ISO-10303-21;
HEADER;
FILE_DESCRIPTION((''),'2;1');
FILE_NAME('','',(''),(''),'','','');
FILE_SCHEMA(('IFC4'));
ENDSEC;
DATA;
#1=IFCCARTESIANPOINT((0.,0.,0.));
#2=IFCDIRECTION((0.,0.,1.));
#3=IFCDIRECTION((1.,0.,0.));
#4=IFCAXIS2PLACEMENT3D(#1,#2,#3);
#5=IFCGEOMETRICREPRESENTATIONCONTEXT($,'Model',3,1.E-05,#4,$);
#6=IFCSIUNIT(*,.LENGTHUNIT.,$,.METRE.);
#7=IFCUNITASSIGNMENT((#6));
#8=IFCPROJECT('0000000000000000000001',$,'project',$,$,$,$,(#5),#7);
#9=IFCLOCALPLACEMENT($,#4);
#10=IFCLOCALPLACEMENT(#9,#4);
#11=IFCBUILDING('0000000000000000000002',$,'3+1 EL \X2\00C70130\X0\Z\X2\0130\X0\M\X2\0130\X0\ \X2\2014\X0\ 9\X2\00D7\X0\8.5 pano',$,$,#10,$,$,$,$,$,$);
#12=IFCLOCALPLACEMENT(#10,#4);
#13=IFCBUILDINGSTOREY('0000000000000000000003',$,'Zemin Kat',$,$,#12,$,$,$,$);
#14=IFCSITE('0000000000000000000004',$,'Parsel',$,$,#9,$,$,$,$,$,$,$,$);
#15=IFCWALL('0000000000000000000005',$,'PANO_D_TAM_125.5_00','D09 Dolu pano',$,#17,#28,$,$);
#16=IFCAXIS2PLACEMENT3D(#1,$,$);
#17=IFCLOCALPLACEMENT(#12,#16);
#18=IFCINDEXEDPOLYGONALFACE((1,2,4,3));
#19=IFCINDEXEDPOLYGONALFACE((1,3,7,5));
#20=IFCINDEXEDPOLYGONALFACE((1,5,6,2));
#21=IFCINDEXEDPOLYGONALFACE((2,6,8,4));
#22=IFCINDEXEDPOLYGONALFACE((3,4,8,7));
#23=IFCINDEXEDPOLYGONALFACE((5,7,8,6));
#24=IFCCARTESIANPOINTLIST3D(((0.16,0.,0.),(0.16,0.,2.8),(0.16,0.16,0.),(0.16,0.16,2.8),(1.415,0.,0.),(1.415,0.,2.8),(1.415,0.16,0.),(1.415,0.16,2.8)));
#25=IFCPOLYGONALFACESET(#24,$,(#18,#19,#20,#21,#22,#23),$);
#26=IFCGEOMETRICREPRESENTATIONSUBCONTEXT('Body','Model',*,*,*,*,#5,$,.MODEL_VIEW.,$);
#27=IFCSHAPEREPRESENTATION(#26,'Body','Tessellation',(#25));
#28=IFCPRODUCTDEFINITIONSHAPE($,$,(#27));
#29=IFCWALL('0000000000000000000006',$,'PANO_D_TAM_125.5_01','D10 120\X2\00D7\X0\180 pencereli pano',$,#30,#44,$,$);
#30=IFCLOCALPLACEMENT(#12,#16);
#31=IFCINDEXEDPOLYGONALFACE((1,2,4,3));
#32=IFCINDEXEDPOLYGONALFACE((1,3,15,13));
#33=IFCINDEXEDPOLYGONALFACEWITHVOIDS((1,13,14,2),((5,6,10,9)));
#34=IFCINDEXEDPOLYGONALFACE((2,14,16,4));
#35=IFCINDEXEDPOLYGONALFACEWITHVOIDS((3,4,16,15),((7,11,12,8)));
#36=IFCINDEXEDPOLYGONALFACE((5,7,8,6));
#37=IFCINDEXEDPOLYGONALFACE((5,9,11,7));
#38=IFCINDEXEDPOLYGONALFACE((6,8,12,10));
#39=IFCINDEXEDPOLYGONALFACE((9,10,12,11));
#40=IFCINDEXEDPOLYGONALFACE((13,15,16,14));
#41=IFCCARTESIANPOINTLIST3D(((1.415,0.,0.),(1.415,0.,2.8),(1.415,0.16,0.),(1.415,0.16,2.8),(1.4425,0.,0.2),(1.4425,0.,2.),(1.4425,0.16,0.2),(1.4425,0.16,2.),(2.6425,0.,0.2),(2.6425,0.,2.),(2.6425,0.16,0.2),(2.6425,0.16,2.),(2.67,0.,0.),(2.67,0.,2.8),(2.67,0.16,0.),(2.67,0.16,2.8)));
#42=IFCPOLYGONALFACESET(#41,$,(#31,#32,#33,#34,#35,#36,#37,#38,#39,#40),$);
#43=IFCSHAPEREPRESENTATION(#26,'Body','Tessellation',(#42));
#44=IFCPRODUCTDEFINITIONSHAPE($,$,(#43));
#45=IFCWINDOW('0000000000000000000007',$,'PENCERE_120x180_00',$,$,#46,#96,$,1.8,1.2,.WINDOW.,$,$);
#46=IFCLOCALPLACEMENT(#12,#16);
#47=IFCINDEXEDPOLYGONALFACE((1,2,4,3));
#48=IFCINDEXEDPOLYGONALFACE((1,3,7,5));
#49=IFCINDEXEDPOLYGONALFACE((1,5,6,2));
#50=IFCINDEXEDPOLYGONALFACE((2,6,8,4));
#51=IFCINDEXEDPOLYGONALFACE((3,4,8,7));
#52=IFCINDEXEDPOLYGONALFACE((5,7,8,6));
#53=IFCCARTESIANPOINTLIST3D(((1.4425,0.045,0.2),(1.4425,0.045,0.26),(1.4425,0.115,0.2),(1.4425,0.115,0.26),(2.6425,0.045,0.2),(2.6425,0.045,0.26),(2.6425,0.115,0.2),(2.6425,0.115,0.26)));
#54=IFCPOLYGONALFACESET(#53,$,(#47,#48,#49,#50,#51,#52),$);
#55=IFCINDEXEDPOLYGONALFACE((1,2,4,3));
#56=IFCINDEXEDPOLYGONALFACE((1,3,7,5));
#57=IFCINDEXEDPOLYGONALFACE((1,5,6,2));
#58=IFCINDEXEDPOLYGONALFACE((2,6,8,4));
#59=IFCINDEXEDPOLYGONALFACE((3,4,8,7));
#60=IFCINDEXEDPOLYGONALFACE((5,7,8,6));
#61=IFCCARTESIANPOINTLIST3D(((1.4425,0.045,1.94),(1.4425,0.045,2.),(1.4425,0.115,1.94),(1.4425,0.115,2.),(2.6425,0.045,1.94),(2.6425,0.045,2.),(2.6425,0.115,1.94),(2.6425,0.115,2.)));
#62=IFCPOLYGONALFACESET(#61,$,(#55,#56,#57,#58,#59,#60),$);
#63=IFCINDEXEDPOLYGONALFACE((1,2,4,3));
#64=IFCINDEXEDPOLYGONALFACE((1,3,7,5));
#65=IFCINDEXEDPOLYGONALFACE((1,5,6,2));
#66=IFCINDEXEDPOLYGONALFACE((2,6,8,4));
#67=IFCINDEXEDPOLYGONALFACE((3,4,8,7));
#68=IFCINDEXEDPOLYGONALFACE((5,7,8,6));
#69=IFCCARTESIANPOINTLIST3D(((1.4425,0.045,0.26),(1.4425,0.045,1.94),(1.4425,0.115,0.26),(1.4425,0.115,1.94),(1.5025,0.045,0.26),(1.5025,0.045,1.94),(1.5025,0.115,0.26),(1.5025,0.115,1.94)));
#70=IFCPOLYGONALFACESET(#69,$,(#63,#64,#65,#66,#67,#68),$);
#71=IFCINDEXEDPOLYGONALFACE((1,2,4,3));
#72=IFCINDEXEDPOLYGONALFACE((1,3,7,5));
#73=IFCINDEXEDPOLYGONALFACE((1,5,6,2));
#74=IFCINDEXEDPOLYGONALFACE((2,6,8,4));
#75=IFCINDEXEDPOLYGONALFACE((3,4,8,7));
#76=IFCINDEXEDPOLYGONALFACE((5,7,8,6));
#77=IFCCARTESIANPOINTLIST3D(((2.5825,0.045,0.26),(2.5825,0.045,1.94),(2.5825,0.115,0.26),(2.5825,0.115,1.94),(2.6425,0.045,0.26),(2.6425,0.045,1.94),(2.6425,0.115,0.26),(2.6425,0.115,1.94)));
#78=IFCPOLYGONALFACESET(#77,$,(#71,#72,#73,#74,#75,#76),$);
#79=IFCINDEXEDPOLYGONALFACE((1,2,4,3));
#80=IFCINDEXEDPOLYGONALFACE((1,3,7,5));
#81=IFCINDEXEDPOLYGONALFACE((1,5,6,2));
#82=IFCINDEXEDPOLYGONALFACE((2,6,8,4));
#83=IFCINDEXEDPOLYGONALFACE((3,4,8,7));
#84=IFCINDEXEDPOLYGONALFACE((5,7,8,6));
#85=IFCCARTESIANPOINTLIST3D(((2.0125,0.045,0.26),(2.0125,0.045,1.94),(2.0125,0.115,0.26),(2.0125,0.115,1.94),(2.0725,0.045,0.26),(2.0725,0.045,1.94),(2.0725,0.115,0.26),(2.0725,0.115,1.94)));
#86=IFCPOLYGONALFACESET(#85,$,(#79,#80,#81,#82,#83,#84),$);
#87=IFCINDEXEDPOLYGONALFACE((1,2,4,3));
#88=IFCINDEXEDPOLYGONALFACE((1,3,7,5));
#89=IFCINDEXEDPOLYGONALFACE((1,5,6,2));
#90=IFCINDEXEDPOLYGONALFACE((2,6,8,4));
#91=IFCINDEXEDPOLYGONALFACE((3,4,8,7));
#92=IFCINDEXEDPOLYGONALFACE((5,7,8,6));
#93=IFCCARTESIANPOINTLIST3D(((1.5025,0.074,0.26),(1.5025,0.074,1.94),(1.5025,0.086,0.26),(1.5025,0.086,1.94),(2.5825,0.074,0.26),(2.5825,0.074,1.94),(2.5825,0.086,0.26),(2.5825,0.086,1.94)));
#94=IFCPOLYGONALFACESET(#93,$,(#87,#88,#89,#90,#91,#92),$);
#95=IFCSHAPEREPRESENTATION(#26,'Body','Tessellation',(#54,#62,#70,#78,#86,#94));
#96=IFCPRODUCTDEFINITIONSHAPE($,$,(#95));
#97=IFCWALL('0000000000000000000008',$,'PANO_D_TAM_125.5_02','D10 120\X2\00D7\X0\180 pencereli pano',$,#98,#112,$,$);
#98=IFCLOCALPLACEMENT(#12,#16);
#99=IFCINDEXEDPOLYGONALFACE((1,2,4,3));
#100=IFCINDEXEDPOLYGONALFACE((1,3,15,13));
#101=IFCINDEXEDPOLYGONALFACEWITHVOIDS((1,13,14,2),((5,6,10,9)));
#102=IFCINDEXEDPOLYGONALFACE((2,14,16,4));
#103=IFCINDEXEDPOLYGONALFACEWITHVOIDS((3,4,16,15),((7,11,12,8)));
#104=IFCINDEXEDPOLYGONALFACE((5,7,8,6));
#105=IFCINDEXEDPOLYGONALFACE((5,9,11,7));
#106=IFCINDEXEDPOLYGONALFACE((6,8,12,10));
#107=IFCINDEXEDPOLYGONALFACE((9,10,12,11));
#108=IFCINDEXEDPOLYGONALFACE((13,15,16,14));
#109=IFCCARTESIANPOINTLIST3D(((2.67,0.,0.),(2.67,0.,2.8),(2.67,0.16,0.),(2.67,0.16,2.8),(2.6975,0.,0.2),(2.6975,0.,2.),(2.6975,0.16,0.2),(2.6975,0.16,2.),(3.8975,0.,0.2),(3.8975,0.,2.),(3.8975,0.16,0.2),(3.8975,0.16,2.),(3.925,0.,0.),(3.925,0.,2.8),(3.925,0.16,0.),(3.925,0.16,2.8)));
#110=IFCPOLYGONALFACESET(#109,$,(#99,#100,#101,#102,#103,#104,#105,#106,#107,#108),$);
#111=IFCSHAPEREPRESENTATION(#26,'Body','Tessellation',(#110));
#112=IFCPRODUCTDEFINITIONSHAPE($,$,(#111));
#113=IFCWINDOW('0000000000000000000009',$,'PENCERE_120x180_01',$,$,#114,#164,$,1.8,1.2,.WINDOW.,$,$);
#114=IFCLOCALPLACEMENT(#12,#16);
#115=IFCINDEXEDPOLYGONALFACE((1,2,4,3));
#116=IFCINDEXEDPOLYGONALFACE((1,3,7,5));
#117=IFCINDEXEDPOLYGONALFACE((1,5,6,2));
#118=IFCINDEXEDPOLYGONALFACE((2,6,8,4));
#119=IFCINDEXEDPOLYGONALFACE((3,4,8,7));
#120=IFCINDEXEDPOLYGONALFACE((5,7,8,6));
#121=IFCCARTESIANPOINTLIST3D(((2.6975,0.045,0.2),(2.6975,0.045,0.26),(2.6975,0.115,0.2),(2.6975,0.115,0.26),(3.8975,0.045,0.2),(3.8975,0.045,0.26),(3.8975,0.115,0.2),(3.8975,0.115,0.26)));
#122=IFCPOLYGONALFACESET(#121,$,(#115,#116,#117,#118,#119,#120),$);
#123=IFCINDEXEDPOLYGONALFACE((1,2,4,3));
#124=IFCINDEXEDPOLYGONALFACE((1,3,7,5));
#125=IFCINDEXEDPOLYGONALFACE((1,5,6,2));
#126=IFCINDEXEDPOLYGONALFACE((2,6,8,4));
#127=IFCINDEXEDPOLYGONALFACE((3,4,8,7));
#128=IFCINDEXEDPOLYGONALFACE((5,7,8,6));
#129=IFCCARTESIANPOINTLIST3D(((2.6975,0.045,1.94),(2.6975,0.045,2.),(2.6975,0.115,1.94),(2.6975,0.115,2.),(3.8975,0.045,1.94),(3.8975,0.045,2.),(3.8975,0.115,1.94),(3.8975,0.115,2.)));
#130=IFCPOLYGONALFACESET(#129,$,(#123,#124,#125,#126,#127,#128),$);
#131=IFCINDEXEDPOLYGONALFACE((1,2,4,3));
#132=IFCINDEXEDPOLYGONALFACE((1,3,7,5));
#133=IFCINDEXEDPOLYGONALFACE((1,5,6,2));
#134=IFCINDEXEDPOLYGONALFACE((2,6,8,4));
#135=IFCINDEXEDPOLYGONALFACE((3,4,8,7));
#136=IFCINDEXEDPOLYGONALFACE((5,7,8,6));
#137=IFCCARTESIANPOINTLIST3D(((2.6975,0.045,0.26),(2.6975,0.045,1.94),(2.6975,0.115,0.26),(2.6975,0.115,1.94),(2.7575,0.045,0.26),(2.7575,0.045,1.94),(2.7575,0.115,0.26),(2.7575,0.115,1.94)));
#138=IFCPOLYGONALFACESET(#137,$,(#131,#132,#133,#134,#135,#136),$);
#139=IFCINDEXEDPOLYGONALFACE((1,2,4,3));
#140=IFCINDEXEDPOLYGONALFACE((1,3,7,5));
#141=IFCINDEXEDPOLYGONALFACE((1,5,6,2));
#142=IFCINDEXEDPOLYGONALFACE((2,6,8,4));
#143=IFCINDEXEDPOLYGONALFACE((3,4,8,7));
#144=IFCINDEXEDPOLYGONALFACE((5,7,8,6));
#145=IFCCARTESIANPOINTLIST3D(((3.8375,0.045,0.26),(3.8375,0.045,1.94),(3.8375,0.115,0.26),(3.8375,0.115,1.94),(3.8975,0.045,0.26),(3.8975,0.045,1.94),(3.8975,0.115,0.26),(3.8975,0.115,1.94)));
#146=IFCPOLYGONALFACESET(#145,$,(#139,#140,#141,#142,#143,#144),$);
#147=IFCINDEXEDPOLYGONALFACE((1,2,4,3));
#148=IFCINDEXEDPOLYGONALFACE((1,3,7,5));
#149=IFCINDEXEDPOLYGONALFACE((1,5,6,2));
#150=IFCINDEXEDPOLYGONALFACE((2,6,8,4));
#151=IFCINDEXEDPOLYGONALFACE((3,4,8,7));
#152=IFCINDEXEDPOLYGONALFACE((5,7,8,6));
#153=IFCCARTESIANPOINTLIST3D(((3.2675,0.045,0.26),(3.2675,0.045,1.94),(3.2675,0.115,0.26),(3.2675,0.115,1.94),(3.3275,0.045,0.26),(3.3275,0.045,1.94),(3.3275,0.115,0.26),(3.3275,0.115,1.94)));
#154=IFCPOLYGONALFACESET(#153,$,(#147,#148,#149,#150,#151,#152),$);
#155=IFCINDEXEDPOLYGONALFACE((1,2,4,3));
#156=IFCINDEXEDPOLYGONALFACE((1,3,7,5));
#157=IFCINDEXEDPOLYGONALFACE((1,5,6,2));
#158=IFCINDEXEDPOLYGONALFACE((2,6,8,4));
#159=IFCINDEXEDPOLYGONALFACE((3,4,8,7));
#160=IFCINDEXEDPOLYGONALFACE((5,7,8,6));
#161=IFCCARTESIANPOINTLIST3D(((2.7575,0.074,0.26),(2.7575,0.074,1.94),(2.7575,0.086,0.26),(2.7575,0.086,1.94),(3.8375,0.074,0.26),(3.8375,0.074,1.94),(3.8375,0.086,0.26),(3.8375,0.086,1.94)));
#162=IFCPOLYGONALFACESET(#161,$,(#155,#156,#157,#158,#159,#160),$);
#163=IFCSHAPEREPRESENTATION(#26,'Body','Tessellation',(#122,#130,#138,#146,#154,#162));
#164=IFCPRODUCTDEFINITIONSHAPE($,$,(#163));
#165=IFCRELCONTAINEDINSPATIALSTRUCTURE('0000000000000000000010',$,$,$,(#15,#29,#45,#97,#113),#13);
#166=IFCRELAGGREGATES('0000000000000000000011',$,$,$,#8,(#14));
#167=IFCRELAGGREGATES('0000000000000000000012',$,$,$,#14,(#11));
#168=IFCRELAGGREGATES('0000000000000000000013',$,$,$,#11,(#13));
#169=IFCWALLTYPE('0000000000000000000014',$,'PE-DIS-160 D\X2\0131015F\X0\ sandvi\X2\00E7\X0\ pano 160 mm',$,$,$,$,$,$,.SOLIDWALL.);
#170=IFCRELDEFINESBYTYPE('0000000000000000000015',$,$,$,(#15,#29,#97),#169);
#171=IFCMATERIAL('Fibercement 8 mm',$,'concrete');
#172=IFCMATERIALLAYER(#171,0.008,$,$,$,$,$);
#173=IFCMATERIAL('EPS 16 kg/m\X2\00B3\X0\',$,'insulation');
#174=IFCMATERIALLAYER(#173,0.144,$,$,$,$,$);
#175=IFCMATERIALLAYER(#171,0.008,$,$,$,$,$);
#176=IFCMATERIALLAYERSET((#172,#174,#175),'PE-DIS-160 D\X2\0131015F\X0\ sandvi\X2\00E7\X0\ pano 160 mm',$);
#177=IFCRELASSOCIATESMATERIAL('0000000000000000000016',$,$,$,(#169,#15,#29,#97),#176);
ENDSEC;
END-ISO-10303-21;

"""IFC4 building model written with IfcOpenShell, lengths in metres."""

from ifc_helpers import new_model, si_unit, frame, origin_with_axes, place, context, subcontext, project, spatial, line, indexed_curve, outline, extrude, material, layer, layer_set, layer_usage, type_object, element, fill, save


model = new_model("IFC4")

# Units and contexts
model_context = context("Model", 3, precision=1e-05, world=origin_with_axes())
body_context = subcontext(model_context, "Body", "Model", "MODEL_VIEW")
ifc_project = project(units=[si_unit("LENGTHUNIT", "METRE")], contexts=[model_context])

# Site, building, storey
site_placement = place(None, origin_with_axes())
site = spatial("IfcSite", under=ifc_project, at=site_placement, Name="Parsel")
building_placement = place(site_placement, origin_with_axes())
building = spatial("IfcBuilding", under=site, at=building_placement, Name="3+1 EL ÇİZİMİ — 9×8.5 pano")
storey_placement = place(building_placement, origin_with_axes())
storey = spatial("IfcBuildingStorey", under=building, at=storey_placement, Name="Zemin Kat")

# Wall
ifc_material_1 = material(Name="Fibercement 8 mm", Category="concrete")
ifc_layer_1 = layer(ifc_material_1, 0.008)
ifc_material_2 = material(Name="EPS 16 kg/m³", Category="insulation")
ifc_layer_2 = layer(ifc_material_2, 0.144)
ifc_layer_3 = layer(ifc_material_1, 0.008)
ifc_layer_set = layer_set([ifc_layer_1, ifc_layer_2, ifc_layer_3], Name="PE-DIS-160 Dış sandviç pano 160 mm")
ifc_layer_usage_1 = layer_usage(ifc_layer_set, "AXIS2", "POSITIVE", 0.0)
wall_type = type_object("IfcWallType", Name="PE-DIS-160 Dış sandviç pano 160 mm", PredefinedType="SOLIDWALL", material=ifc_layer_set)
wall_1_placement = place(storey_placement, frame((0.16, 0.0, 0.0), z_axis=(0.0, 0.0, 1.0), x_axis=(1.0, 0.0, 0.0)))
element("IfcWall", 1, at=wall_1_placement, inside=storey, type_object=wall_type, material=ifc_layer_usage_1, Name="PANO_D_TAM_125.5_00", Description="D09 Dolu pano", context=body_context, shape_type="SweptSolid", body=[
    extrude(outline(indexed_curve([(0.0, 0.0), (1.255, 0.0), (1.255, 0.16), (0.0, 0.16)], segments=[line(1, 2, 3, 4, 1)])), origin_with_axes(), (0.0, 0.0, 1.0), 2.8),
])

# Walls, openings, windows
ifc_layer_usage_2 = layer_usage(ifc_layer_set, "AXIS2", "POSITIVE", 0.0)
wall_2_placement = place(storey_placement, frame((1.415, 0.0, 0.0), z_axis=(0.0, 0.0, 1.0), x_axis=(1.0, 0.0, 0.0)))
wall_2 = element("IfcWall", 2, at=wall_2_placement, inside=storey, type_object=wall_type, material=ifc_layer_usage_2, Name="PANO_D_TAM_125.5_01", Description="D10 120×180 pencereli pano", context=body_context, shape_type="SweptSolid", body=[
    extrude(outline(indexed_curve([(0.0, 0.0), (1.255, 0.0), (1.255, 0.16), (0.0, 0.16)], segments=[line(1, 2, 3, 4, 1)])), origin_with_axes(), (0.0, 0.0, 1.0), 2.8),
])
opening_1_placement = place(wall_2_placement, origin_with_axes())
opening_1 = element("IfcOpeningElement", 3, at=opening_1_placement, cuts=wall_2, PredefinedType="OPENING", context=body_context, shape_type="SweptSolid", body=[
    extrude(outline(indexed_curve([(0.0, 0.0), (1.2, 0.0), (1.2, 0.2), (0.0, 0.2)], segments=[line(1, 2, 3, 4, 1)])), frame((0.0275, -0.02, 0.2), z_axis=(0.0, 0.0, 1.0), x_axis=(1.0, 0.0, 0.0)), (0.0, 0.0, 1.0), 1.8),
])
window_1_placement = place(storey_placement, frame((1.415, 0.0, 0.0), z_axis=(0.0, 0.0, 1.0), x_axis=(1.0, 0.0, 0.0)))
window_1 = element("IfcWindow", 4, at=window_1_placement, inside=storey, Name="PENCERE_120x180_00", OverallHeight=1.8, OverallWidth=1.2, PredefinedType="WINDOW", context=body_context, shape_type="SweptSolid", body=[
    extrude(outline(indexed_curve([(0.0, 0.0), (1.2, 0.0), (1.2, 0.07), (0.0, 0.07)], segments=[line(1, 2, 3, 4, 1)])), frame((0.0275, 0.045, 0.2), z_axis=(0.0, 0.0, 1.0), x_axis=(1.0, 0.0, 0.0)), (0.0, 0.0, 1.0), 0.06),
    extrude(outline(indexed_curve([(0.0, 0.0), (1.2, 0.0), (1.2, 0.07), (0.0, 0.07)], segments=[line(1, 2, 3, 4, 1)])), frame((0.0275, 0.045, 1.94), z_axis=(0.0, 0.0, 1.0), x_axis=(1.0, 0.0, 0.0)), (0.0, 0.0, 1.0), 0.06),
    extrude(outline(indexed_curve([(0.0, 0.0), (0.06, 0.0), (0.06, 0.07), (0.0, 0.07)], segments=[line(1, 2, 3, 4, 1)])), frame((0.0275, 0.045, 0.26), z_axis=(0.0, 0.0, 1.0), x_axis=(1.0, 0.0, 0.0)), (0.0, 0.0, 1.0), 1.68),
    extrude(outline(indexed_curve([(0.0, 0.0), (0.06, 0.0), (0.06, 0.07), (0.0, 0.07)], segments=[line(1, 2, 3, 4, 1)])), frame((1.1675, 0.045, 0.26), z_axis=(0.0, 0.0, 1.0), x_axis=(1.0, 0.0, 0.0)), (0.0, 0.0, 1.0), 1.68),
    extrude(outline(indexed_curve([(0.0, 0.0), (0.06, 0.0), (0.06, 0.07), (0.0, 0.07)], segments=[line(1, 2, 3, 4, 1)])), frame((0.5975, 0.045, 0.26), z_axis=(0.0, 0.0, 1.0), x_axis=(1.0, 0.0, 0.0)), (0.0, 0.0, 1.0), 1.68),
    extrude(outline(indexed_curve([(0.0, 0.0), (1.08, 0.0), (1.08, 0.012), (0.0, 0.012)], segments=[line(1, 2, 3, 4, 1)])), frame((0.0875, 0.074, 0.26), z_axis=(0.0, 0.0, 1.0), x_axis=(1.0, 0.0, 0.0)), (0.0, 0.0, 1.0), 1.68),
])
fill(opening_1, window_1)
ifc_layer_usage_3 = layer_usage(ifc_layer_set, "AXIS2", "POSITIVE", 0.0)
wall_3_placement = place(storey_placement, frame((2.67, 0.0, 0.0), z_axis=(0.0, 0.0, 1.0), x_axis=(1.0, 0.0, 0.0)))
wall_3 = element("IfcWall", 5, at=wall_3_placement, inside=storey, type_object=wall_type, material=ifc_layer_usage_3, Name="PANO_D_TAM_125.5_02", Description="D10 120×180 pencereli pano", context=body_context, shape_type="SweptSolid", body=[
    extrude(outline(indexed_curve([(0.0, 0.0), (1.255, 0.0), (1.255, 0.16), (0.0, 0.16)], segments=[line(1, 2, 3, 4, 1)])), origin_with_axes(), (0.0, 0.0, 1.0), 2.8),
])
opening_2_placement = place(wall_3_placement, origin_with_axes())
opening_2 = element("IfcOpeningElement", 6, at=opening_2_placement, cuts=wall_3, PredefinedType="OPENING", context=body_context, shape_type="SweptSolid", body=[
    extrude(outline(indexed_curve([(0.0, 0.0), (1.2, 0.0), (1.2, 0.2), (0.0, 0.2)], segments=[line(1, 2, 3, 4, 1)])), frame((0.0275, -0.02, 0.2), z_axis=(0.0, 0.0, 1.0), x_axis=(1.0, 0.0, 0.0)), (0.0, 0.0, 1.0), 1.8),
])
window_2_placement = place(storey_placement, frame((2.67, 0.0, 0.0), z_axis=(0.0, 0.0, 1.0), x_axis=(1.0, 0.0, 0.0)))
window_2 = element("IfcWindow", 7, at=window_2_placement, inside=storey, Name="PENCERE_120x180_01", OverallHeight=1.8, OverallWidth=1.2, PredefinedType="WINDOW", context=body_context, shape_type="SweptSolid", body=[
    extrude(outline(indexed_curve([(0.0, 0.0), (1.2, 0.0), (1.2, 0.07), (0.0, 0.07)], segments=[line(1, 2, 3, 4, 1)])), frame((0.0275, 0.045, 0.2), z_axis=(0.0, 0.0, 1.0), x_axis=(1.0, 0.0, 0.0)), (0.0, 0.0, 1.0), 0.06),
    extrude(outline(indexed_curve([(0.0, 0.0), (1.2, 0.0), (1.2, 0.07), (0.0, 0.07)], segments=[line(1, 2, 3, 4, 1)])), frame((0.0275, 0.045, 1.94), z_axis=(0.0, 0.0, 1.0), x_axis=(1.0, 0.0, 0.0)), (0.0, 0.0, 1.0), 0.06),
    extrude(outline(indexed_curve([(0.0, 0.0), (0.06, 0.0), (0.06, 0.07), (0.0, 0.07)], segments=[line(1, 2, 3, 4, 1)])), frame((0.0275, 0.045, 0.26), z_axis=(0.0, 0.0, 1.0), x_axis=(1.0, 0.0, 0.0)), (0.0, 0.0, 1.0), 1.68),
    extrude(outline(indexed_curve([(0.0, 0.0), (0.06, 0.0), (0.06, 0.07), (0.0, 0.07)], segments=[line(1, 2, 3, 4, 1)])), frame((1.1675, 0.045, 0.26), z_axis=(0.0, 0.0, 1.0), x_axis=(1.0, 0.0, 0.0)), (0.0, 0.0, 1.0), 1.68),
    extrude(outline(indexed_curve([(0.0, 0.0), (0.06, 0.0), (0.06, 0.07), (0.0, 0.07)], segments=[line(1, 2, 3, 4, 1)])), frame((0.5975, 0.045, 0.26), z_axis=(0.0, 0.0, 1.0), x_axis=(1.0, 0.0, 0.0)), (0.0, 0.0, 1.0), 1.68),
    extrude(outline(indexed_curve([(0.0, 0.0), (1.08, 0.0), (1.08, 0.012), (0.0, 0.012)], segments=[line(1, 2, 3, 4, 1)])), frame((0.0875, 0.074, 0.26), z_axis=(0.0, 0.0, 1.0), x_axis=(1.0, 0.0, 0.0)), (0.0, 0.0, 1.0), 1.68),
])
fill(opening_2, window_2)

save(model, "model.ifc")
